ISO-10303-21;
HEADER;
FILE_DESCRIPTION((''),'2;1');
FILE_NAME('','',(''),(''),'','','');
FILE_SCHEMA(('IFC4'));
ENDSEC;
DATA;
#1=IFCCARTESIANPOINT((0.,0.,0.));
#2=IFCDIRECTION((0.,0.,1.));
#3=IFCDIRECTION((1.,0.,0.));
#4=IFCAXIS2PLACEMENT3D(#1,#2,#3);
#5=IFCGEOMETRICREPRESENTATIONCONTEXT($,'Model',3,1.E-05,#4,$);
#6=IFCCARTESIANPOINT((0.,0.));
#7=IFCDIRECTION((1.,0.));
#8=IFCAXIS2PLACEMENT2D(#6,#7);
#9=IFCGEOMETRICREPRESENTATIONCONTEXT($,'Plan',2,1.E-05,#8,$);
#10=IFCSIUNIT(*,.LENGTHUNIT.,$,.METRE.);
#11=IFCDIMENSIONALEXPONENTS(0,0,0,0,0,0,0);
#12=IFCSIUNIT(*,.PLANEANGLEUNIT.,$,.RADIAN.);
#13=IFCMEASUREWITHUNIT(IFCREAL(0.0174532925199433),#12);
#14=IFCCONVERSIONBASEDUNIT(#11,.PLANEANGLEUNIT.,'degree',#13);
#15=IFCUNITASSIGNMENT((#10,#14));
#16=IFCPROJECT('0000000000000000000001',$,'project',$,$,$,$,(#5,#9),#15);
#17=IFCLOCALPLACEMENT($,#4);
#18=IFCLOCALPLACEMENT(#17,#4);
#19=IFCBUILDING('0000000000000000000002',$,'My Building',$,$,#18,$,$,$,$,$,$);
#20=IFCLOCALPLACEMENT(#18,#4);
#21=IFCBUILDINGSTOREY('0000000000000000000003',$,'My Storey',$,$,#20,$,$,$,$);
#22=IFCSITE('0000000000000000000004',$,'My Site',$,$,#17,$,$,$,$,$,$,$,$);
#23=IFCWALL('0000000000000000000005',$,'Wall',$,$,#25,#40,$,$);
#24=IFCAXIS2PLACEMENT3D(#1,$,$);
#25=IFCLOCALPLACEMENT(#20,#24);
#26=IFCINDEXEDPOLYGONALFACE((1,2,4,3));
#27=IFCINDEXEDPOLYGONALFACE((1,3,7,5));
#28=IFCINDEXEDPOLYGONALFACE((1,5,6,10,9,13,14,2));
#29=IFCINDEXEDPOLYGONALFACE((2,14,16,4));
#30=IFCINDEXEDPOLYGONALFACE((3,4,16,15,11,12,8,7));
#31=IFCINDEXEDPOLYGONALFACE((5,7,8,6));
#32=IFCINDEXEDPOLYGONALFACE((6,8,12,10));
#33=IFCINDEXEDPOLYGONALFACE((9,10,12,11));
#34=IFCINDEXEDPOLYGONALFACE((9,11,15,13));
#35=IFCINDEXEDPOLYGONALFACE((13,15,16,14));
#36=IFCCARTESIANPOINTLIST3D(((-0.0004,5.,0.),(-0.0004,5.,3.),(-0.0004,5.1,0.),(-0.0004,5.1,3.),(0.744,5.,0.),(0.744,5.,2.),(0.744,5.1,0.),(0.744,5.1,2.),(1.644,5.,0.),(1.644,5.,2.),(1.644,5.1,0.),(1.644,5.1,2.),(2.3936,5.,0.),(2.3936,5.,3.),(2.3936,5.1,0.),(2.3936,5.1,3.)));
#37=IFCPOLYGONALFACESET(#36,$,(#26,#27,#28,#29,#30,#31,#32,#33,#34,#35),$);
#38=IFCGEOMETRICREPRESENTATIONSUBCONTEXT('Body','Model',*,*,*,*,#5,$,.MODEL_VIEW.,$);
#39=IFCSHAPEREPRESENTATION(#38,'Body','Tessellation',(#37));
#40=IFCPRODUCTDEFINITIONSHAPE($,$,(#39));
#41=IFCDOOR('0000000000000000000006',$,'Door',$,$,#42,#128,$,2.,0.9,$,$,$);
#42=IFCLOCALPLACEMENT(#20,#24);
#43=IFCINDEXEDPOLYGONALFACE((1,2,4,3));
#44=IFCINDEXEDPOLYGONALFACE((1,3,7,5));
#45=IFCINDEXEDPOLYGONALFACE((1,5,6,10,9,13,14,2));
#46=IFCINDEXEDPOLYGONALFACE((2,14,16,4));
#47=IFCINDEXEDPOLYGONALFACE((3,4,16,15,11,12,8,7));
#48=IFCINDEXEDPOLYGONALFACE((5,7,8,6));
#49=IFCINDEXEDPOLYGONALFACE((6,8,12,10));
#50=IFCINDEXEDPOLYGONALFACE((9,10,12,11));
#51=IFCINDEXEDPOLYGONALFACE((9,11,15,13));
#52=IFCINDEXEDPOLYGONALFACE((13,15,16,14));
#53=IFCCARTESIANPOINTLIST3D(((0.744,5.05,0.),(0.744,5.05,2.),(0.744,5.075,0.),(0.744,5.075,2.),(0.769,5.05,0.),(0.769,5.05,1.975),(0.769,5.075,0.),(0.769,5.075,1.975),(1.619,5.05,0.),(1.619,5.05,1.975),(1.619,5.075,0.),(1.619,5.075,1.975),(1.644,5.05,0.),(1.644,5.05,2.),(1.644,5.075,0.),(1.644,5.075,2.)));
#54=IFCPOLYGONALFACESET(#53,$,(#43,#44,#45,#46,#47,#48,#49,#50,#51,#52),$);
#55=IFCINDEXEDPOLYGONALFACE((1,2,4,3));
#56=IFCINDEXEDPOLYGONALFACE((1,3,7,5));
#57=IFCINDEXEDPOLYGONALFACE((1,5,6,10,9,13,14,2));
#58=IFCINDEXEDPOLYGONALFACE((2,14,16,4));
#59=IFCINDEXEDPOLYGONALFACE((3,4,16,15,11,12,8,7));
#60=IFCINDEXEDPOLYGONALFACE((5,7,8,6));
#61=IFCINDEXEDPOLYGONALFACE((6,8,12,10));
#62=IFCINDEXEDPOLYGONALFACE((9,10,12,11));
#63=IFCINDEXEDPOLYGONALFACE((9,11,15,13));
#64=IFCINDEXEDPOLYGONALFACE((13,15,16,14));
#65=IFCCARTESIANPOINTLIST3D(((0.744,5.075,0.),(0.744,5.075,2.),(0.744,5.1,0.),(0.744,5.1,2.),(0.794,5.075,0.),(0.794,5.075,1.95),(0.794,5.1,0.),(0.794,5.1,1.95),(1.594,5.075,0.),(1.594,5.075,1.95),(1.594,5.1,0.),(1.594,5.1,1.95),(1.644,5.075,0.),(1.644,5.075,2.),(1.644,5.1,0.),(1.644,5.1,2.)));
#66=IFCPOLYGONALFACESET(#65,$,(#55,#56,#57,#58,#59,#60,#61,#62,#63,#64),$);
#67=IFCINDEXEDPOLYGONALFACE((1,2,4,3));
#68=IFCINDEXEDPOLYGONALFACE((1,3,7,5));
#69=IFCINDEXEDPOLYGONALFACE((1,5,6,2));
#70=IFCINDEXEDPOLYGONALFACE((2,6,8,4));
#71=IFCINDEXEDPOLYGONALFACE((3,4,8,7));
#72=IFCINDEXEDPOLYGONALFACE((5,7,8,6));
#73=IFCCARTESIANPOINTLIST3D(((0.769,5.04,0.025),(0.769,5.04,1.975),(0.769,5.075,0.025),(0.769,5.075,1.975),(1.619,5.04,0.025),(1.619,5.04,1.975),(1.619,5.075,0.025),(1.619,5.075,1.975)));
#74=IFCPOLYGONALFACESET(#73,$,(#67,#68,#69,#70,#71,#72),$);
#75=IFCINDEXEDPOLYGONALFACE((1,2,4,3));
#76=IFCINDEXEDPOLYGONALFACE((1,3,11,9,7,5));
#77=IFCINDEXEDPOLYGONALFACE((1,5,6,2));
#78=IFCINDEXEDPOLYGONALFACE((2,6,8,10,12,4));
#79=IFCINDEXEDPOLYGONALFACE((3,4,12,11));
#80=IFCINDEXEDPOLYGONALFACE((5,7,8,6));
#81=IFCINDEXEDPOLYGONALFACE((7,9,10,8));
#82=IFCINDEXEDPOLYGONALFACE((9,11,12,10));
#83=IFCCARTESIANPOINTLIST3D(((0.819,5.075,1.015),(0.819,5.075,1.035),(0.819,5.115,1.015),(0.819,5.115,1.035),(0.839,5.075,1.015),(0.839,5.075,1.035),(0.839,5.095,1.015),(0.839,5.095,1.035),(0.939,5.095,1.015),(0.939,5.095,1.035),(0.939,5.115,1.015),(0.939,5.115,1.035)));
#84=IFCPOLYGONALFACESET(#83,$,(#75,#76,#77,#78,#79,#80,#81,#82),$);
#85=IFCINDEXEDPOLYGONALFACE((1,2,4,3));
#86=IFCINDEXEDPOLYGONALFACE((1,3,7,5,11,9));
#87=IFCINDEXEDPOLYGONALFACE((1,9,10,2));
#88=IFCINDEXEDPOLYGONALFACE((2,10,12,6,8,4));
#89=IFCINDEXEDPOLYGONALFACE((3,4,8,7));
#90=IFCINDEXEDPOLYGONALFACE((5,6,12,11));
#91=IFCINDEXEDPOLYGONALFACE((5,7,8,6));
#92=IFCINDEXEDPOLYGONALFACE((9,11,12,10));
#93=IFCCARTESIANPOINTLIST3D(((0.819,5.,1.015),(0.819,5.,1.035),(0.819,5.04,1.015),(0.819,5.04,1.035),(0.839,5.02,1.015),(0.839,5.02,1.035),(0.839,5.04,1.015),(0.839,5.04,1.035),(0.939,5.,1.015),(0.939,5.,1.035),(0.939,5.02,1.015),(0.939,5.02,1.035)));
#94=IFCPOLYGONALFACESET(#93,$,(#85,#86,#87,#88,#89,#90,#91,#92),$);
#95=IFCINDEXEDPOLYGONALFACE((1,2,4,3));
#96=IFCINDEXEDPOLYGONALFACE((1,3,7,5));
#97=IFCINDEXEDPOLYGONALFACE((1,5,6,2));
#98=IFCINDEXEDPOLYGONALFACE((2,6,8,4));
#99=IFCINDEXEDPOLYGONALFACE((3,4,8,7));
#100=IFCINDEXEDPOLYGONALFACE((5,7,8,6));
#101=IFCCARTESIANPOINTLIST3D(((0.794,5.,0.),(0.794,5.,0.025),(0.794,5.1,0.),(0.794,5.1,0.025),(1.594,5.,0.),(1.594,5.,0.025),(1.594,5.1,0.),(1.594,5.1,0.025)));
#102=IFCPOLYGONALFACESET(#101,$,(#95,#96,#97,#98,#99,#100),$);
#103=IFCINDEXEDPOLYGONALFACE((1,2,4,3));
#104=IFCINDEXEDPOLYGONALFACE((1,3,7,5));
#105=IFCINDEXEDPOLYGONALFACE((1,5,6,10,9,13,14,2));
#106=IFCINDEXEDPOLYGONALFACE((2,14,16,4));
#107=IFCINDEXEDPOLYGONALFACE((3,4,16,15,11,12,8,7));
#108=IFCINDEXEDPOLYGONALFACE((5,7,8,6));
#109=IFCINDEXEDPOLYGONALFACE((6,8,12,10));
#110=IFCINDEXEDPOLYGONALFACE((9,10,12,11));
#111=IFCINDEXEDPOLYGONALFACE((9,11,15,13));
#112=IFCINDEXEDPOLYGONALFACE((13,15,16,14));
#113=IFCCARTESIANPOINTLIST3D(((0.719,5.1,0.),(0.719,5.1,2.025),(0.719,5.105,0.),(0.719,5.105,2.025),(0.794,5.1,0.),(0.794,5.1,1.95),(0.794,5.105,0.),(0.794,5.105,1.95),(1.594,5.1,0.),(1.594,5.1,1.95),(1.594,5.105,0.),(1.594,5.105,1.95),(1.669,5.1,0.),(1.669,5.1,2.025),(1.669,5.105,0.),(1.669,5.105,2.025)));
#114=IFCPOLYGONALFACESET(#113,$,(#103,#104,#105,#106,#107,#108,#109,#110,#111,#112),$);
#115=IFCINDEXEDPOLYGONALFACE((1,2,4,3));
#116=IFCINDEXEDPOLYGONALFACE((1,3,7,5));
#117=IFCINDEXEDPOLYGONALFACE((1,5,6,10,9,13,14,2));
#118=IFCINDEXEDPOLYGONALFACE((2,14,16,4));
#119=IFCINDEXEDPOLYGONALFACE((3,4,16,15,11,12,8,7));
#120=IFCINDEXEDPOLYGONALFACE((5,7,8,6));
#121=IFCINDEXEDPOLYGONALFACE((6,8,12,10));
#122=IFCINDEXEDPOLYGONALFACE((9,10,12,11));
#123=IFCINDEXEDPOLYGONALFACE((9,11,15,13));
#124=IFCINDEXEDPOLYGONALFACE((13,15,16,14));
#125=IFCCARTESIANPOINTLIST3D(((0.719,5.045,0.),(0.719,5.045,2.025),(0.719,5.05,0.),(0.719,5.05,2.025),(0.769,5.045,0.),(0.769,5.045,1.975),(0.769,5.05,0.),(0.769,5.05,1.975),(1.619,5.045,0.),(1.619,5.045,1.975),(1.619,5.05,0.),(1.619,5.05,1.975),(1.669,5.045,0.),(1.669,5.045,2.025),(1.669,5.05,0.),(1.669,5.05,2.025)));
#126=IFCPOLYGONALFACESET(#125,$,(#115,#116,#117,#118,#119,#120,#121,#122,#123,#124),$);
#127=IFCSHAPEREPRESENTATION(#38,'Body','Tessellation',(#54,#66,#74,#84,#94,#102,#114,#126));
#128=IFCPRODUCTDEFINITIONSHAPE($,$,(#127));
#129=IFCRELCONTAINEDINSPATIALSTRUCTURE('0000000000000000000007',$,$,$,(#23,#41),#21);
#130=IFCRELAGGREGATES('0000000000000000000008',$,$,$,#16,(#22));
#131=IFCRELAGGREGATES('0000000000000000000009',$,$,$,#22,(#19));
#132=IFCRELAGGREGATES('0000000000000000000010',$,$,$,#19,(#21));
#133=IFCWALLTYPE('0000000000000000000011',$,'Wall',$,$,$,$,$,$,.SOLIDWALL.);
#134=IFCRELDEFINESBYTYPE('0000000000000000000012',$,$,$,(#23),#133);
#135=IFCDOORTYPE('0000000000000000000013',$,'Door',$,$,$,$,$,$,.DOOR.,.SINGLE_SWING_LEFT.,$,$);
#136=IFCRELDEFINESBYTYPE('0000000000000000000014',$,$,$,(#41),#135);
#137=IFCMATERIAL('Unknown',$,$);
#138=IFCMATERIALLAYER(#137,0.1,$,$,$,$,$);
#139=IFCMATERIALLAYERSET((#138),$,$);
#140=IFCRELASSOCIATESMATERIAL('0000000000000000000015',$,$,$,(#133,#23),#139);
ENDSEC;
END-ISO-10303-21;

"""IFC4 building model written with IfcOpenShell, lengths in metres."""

from ifc_helpers import new_model, entity, si_unit, converted_unit, frame, origin_with_axes, origin_2d_with_axis, place, context, subcontext, project, spatial, line, indexed_curve, outline, extrude, shape, source, transform, mapped, material, layer, layer_set, layer_usage, type_object, type_shapes, element, fill, save


model = new_model("IFC4")

# Units and contexts
model_context = context("Model", 3, precision=1e-05, world=origin_with_axes())
plan_context = context("Plan", 2, precision=1e-05, world=origin_2d_with_axis())
body_context_1 = subcontext(model_context, "Body", "Model", "MODEL_VIEW")
body_context_2 = subcontext(plan_context, "Body", "Plan", "PLAN_VIEW")
ifc_project = project(units=[si_unit("LENGTHUNIT", "METRE"), converted_unit("PLANEANGLEUNIT", "degree", entity("IfcReal", 0.0174532925199433), si_unit("PLANEANGLEUNIT", "RADIAN"), dimensions=[0, 0, 0, 0, 0, 0, 0])], contexts=[model_context, plan_context])

# Site, building, storey
site_placement = place(None, origin_with_axes())
site = spatial("IfcSite", under=ifc_project, at=site_placement, Name="My Site")
building_placement = place(site_placement, origin_with_axes())
building = spatial("IfcBuilding", under=site, at=building_placement, Name="My Building")
storey_placement = place(building_placement, origin_with_axes())
storey = spatial("IfcBuildingStorey", under=building, at=storey_placement, Name="My Storey")

# Shared definitions
ifc_material = material(Name="Unknown")

# Shared definitions
ifc_layer = layer(ifc_material, 0.1)
ifc_layer_set = layer_set([ifc_layer])
wall_type = type_object("IfcWallType", Name="Wall", PredefinedType="SOLIDWALL", material=ifc_layer_set)
shared_shape_1 = source(origin_with_axes(), body_context_1, "Body", "SweptSolid", [
    extrude(outline(indexed_curve([(0.0, 0.0), (0.9, 0.0), (0.9, 2.0), (0.0, 2.0)], segments=[line(1, 2, 3, 4, 1)])), frame((0.0, -0.6, 0.0), z_axis=(0.0, -1.0, 0.0), x_axis=(1.0, 0.0, 0.0)), (0.0, 0.0, -1.0), 1.2),
])
door_type = type_object("IfcDoorType", Name="Door", OperationType="SINGLE_SWING_LEFT", PredefinedType="DOOR")
shared_shape_2 = source(origin_with_axes(), body_context_1, "Body", "SweptSolid", [
    extrude(outline(indexed_curve([(0.0, 0.0), (0.0, 2.0), (0.9, 2.0), (0.9, 0.0), (0.875, 0.0), (0.875, 1.975), (0.025, 1.975), (0.025, 0.0)], segments=[line(1, 2, 3, 4, 5, 6, 7, 8, 1)])), frame((0.0, 0.025, 0.0), z_axis=(0.0, -1.0, 0.0), x_axis=(1.0, 0.0, 0.0)), (0.0, 0.0, -1.0), 0.025),
    extrude(outline(indexed_curve([(0.0, 0.0), (0.0, 2.0), (0.9, 2.0), (0.9, 0.0), (0.85, 0.0), (0.85, 1.95), (0.05, 1.95), (0.05, 0.0)], segments=[line(1, 2, 3, 4, 5, 6, 7, 8, 1)])), frame((0.0, 0.0, 0.0), z_axis=(0.0, -1.0, 0.0), x_axis=(1.0, 0.0, 0.0)), (0.0, 0.0, -1.0), 0.025),
    extrude(outline(indexed_curve([(0.0, 0.0), (0.85, 0.0), (0.85, 0.035), (0.0, 0.035)], segments=[line(1, 2, 3, 4, 1)])), frame((0.025, 0.025, 0.025), z_axis=(0.0, 0.0, 1.0), x_axis=(1.0, 0.0, 0.0)), (0.0, 0.0, 1.0), 1.95),
    extrude(outline(indexed_curve([(0.0, 0.0), (0.0, -0.04), (-0.12, -0.04), (-0.12, -0.02), (-0.02, -0.02), (-0.02, 0.0)], segments=[line(1, 2, 3, 4, 5, 6, 1)])), frame((0.825, 0.025, 1.015), z_axis=(0.0, 0.0, 1.0), x_axis=(1.0, 0.0, 0.0)), (0.0, 0.0, 1.0), 0.02),
    extrude(outline(indexed_curve([(0.0, 0.0), (0.0, 0.04), (-0.12, 0.04), (-0.12, 0.02), (-0.02, 0.02), (-0.02, 0.0)], segments=[line(1, 2, 3, 4, 5, 6, 1)])), frame((0.825, 0.06, 1.015), z_axis=(0.0, 0.0, 1.0), x_axis=(1.0, 0.0, 0.0)), (0.0, 0.0, 1.0), 0.02),
    extrude(outline(indexed_curve([(0.0, 0.0), (0.8, 0.0), (0.8, 0.1), (0.0, 0.1)], segments=[line(1, 2, 3, 4, 1)])), frame((0.05, 0.0, 0.0), z_axis=(0.0, 0.0, 1.0), x_axis=(1.0, 0.0, 0.0)), (0.0, 0.0, 1.0), 0.025),
    extrude(outline(indexed_curve([(0.0, 0.0), (0.0, 2.025), (0.95, 2.025), (0.95, 0.0), (0.875, 0.0), (0.875, 1.95), (0.075, 1.95), (0.075, 0.0)], segments=[line(1, 2, 3, 4, 5, 6, 7, 8, 1)])), frame((-0.025, -0.005, 0.0), z_axis=(0.0, -1.0, 0.0), x_axis=(1.0, 0.0, 0.0)), (0.0, 0.0, -1.0), 0.005),
    extrude(outline(indexed_curve([(0.0, 0.0), (0.0, 2.025), (0.95, 2.025), (0.95, 0.0), (0.9, 0.0), (0.9, 1.975), (0.05, 1.975), (0.05, 0.0)], segments=[line(1, 2, 3, 4, 5, 6, 7, 8, 1)])), frame((-0.025, 0.05, 0.0), z_axis=(0.0, -1.0, 0.0), x_axis=(1.0, 0.0, 0.0)), (0.0, 0.0, -1.0), 0.005),
])
shared_shape_3 = source(origin_with_axes(), body_context_2, "Body", "Curve2D", [
    entity("IfcIndexedPolyCurve", entity("IfcCartesianPointList2D", [[0.0, 0.0], [0.0, 0.05], [0.025, 0.05], [0.025, 0.025], [0.05, 0.025], [0.05, 0.0]]), [entity("IfcLineIndex", [1, 2, 3, 4, 5, 6, 1])]),
    entity("IfcIndexedPolyCurve", entity("IfcCartesianPointList2D", [[0.9, 0.0], [0.9, 0.05], [0.875, 0.05], [0.875, 0.025], [0.85, 0.025], [0.85, 0.0]]), [entity("IfcLineIndex", [1, 2, 3, 4, 5, 6, 1])]),
    entity("IfcTrimmedCurve", entity("IfcEllipse", entity("IfcAxis2Placement2D", entity("IfcCartesianPoint", [0.06, 0.05]), entity("IfcDirection", [1.0, 0.0])), 0.815, 0.85), [entity("IfcCartesianPoint", [0.875, 0.05])], [entity("IfcCartesianPoint", [0.06, 0.9])], True, "CARTESIAN"),
    entity("IfcIndexedPolyCurve", entity("IfcCartesianPointList2D", [[0.025, 0.05], [0.06, 0.05], [0.06, 0.9], [0.025, 0.9]]), [entity("IfcLineIndex", [1, 2, 3, 4, 1])]),
])
type_shapes(door_type, [shared_shape_2, shared_shape_3])

# Wall, opening, door
ifc_layer_usage_1 = layer_usage(ifc_layer_set, "AXIS2", "POSITIVE", 0.0)
wall_1_placement = place(storey_placement, frame((2.3936, 5.1, 0.0), z_axis=(0.0, 0.0, 1.0), x_axis=(-1.0, 0.0, 0.0)))
wall_1 = element("IfcWall", 1, at=wall_1_placement, inside=storey, type_object=wall_type, material=ifc_layer_usage_1, Name="Wall", context=body_context_1, shape_type="SweptSolid", body=[
    extrude(outline(indexed_curve([(0.0, 0.0), (0.0, 0.1), (2.394, 0.1), (2.394, 0.0)], segments=[line(1, 2, 3, 4, 1)])), origin_with_axes(), (0.0, 0.0, 1.0), 3.0),
])
opening_1_placement = place(wall_1_placement, frame((0.7496, 0.0, 0.0), z_axis=(0.0, 0.0, 1.0), x_axis=(1.0, 0.0, 0.0)))
opening_1 = element("IfcOpeningElement", 2, at=opening_1_placement, cuts=wall_1, PredefinedType="OPENING", context=body_context_1, shape_type="MappedRepresentation", body=[
    mapped(shared_shape_1, transform((0.0, 0.0, 0.0), x_axis=(1.0, 0.0, 0.0), y_axis=(0.0, 1.0, 0.0), z_axis=(0.0, 0.0, 1.0), scale=1.0)),
])
door_1_placement = place(opening_1_placement, origin_with_axes())
door_1 = element("IfcDoor", 3, at=door_1_placement, inside=storey, type_object=door_type, Name="Door", OverallHeight=2.0, OverallWidth=0.9, shapes=[
    shape(body_context_1, "Body", "MappedRepresentation", [mapped(shared_shape_2, transform((0.0, 0.0, 0.0), x_axis=(1.0, 0.0, 0.0), y_axis=(0.0, 1.0, 0.0), z_axis=(0.0, 0.0, 1.0), scale=1.0))]),
    shape(body_context_2, "Body", "MappedRepresentation", [mapped(shared_shape_3, transform((0.0, 0.0, 0.0), x_axis=(1.0, 0.0, 0.0), y_axis=(0.0, 1.0, 0.0), z_axis=(0.0, 0.0, 1.0), scale=1.0))]),
])
fill(opening_1, door_1)

save(model, "model.ifc")
